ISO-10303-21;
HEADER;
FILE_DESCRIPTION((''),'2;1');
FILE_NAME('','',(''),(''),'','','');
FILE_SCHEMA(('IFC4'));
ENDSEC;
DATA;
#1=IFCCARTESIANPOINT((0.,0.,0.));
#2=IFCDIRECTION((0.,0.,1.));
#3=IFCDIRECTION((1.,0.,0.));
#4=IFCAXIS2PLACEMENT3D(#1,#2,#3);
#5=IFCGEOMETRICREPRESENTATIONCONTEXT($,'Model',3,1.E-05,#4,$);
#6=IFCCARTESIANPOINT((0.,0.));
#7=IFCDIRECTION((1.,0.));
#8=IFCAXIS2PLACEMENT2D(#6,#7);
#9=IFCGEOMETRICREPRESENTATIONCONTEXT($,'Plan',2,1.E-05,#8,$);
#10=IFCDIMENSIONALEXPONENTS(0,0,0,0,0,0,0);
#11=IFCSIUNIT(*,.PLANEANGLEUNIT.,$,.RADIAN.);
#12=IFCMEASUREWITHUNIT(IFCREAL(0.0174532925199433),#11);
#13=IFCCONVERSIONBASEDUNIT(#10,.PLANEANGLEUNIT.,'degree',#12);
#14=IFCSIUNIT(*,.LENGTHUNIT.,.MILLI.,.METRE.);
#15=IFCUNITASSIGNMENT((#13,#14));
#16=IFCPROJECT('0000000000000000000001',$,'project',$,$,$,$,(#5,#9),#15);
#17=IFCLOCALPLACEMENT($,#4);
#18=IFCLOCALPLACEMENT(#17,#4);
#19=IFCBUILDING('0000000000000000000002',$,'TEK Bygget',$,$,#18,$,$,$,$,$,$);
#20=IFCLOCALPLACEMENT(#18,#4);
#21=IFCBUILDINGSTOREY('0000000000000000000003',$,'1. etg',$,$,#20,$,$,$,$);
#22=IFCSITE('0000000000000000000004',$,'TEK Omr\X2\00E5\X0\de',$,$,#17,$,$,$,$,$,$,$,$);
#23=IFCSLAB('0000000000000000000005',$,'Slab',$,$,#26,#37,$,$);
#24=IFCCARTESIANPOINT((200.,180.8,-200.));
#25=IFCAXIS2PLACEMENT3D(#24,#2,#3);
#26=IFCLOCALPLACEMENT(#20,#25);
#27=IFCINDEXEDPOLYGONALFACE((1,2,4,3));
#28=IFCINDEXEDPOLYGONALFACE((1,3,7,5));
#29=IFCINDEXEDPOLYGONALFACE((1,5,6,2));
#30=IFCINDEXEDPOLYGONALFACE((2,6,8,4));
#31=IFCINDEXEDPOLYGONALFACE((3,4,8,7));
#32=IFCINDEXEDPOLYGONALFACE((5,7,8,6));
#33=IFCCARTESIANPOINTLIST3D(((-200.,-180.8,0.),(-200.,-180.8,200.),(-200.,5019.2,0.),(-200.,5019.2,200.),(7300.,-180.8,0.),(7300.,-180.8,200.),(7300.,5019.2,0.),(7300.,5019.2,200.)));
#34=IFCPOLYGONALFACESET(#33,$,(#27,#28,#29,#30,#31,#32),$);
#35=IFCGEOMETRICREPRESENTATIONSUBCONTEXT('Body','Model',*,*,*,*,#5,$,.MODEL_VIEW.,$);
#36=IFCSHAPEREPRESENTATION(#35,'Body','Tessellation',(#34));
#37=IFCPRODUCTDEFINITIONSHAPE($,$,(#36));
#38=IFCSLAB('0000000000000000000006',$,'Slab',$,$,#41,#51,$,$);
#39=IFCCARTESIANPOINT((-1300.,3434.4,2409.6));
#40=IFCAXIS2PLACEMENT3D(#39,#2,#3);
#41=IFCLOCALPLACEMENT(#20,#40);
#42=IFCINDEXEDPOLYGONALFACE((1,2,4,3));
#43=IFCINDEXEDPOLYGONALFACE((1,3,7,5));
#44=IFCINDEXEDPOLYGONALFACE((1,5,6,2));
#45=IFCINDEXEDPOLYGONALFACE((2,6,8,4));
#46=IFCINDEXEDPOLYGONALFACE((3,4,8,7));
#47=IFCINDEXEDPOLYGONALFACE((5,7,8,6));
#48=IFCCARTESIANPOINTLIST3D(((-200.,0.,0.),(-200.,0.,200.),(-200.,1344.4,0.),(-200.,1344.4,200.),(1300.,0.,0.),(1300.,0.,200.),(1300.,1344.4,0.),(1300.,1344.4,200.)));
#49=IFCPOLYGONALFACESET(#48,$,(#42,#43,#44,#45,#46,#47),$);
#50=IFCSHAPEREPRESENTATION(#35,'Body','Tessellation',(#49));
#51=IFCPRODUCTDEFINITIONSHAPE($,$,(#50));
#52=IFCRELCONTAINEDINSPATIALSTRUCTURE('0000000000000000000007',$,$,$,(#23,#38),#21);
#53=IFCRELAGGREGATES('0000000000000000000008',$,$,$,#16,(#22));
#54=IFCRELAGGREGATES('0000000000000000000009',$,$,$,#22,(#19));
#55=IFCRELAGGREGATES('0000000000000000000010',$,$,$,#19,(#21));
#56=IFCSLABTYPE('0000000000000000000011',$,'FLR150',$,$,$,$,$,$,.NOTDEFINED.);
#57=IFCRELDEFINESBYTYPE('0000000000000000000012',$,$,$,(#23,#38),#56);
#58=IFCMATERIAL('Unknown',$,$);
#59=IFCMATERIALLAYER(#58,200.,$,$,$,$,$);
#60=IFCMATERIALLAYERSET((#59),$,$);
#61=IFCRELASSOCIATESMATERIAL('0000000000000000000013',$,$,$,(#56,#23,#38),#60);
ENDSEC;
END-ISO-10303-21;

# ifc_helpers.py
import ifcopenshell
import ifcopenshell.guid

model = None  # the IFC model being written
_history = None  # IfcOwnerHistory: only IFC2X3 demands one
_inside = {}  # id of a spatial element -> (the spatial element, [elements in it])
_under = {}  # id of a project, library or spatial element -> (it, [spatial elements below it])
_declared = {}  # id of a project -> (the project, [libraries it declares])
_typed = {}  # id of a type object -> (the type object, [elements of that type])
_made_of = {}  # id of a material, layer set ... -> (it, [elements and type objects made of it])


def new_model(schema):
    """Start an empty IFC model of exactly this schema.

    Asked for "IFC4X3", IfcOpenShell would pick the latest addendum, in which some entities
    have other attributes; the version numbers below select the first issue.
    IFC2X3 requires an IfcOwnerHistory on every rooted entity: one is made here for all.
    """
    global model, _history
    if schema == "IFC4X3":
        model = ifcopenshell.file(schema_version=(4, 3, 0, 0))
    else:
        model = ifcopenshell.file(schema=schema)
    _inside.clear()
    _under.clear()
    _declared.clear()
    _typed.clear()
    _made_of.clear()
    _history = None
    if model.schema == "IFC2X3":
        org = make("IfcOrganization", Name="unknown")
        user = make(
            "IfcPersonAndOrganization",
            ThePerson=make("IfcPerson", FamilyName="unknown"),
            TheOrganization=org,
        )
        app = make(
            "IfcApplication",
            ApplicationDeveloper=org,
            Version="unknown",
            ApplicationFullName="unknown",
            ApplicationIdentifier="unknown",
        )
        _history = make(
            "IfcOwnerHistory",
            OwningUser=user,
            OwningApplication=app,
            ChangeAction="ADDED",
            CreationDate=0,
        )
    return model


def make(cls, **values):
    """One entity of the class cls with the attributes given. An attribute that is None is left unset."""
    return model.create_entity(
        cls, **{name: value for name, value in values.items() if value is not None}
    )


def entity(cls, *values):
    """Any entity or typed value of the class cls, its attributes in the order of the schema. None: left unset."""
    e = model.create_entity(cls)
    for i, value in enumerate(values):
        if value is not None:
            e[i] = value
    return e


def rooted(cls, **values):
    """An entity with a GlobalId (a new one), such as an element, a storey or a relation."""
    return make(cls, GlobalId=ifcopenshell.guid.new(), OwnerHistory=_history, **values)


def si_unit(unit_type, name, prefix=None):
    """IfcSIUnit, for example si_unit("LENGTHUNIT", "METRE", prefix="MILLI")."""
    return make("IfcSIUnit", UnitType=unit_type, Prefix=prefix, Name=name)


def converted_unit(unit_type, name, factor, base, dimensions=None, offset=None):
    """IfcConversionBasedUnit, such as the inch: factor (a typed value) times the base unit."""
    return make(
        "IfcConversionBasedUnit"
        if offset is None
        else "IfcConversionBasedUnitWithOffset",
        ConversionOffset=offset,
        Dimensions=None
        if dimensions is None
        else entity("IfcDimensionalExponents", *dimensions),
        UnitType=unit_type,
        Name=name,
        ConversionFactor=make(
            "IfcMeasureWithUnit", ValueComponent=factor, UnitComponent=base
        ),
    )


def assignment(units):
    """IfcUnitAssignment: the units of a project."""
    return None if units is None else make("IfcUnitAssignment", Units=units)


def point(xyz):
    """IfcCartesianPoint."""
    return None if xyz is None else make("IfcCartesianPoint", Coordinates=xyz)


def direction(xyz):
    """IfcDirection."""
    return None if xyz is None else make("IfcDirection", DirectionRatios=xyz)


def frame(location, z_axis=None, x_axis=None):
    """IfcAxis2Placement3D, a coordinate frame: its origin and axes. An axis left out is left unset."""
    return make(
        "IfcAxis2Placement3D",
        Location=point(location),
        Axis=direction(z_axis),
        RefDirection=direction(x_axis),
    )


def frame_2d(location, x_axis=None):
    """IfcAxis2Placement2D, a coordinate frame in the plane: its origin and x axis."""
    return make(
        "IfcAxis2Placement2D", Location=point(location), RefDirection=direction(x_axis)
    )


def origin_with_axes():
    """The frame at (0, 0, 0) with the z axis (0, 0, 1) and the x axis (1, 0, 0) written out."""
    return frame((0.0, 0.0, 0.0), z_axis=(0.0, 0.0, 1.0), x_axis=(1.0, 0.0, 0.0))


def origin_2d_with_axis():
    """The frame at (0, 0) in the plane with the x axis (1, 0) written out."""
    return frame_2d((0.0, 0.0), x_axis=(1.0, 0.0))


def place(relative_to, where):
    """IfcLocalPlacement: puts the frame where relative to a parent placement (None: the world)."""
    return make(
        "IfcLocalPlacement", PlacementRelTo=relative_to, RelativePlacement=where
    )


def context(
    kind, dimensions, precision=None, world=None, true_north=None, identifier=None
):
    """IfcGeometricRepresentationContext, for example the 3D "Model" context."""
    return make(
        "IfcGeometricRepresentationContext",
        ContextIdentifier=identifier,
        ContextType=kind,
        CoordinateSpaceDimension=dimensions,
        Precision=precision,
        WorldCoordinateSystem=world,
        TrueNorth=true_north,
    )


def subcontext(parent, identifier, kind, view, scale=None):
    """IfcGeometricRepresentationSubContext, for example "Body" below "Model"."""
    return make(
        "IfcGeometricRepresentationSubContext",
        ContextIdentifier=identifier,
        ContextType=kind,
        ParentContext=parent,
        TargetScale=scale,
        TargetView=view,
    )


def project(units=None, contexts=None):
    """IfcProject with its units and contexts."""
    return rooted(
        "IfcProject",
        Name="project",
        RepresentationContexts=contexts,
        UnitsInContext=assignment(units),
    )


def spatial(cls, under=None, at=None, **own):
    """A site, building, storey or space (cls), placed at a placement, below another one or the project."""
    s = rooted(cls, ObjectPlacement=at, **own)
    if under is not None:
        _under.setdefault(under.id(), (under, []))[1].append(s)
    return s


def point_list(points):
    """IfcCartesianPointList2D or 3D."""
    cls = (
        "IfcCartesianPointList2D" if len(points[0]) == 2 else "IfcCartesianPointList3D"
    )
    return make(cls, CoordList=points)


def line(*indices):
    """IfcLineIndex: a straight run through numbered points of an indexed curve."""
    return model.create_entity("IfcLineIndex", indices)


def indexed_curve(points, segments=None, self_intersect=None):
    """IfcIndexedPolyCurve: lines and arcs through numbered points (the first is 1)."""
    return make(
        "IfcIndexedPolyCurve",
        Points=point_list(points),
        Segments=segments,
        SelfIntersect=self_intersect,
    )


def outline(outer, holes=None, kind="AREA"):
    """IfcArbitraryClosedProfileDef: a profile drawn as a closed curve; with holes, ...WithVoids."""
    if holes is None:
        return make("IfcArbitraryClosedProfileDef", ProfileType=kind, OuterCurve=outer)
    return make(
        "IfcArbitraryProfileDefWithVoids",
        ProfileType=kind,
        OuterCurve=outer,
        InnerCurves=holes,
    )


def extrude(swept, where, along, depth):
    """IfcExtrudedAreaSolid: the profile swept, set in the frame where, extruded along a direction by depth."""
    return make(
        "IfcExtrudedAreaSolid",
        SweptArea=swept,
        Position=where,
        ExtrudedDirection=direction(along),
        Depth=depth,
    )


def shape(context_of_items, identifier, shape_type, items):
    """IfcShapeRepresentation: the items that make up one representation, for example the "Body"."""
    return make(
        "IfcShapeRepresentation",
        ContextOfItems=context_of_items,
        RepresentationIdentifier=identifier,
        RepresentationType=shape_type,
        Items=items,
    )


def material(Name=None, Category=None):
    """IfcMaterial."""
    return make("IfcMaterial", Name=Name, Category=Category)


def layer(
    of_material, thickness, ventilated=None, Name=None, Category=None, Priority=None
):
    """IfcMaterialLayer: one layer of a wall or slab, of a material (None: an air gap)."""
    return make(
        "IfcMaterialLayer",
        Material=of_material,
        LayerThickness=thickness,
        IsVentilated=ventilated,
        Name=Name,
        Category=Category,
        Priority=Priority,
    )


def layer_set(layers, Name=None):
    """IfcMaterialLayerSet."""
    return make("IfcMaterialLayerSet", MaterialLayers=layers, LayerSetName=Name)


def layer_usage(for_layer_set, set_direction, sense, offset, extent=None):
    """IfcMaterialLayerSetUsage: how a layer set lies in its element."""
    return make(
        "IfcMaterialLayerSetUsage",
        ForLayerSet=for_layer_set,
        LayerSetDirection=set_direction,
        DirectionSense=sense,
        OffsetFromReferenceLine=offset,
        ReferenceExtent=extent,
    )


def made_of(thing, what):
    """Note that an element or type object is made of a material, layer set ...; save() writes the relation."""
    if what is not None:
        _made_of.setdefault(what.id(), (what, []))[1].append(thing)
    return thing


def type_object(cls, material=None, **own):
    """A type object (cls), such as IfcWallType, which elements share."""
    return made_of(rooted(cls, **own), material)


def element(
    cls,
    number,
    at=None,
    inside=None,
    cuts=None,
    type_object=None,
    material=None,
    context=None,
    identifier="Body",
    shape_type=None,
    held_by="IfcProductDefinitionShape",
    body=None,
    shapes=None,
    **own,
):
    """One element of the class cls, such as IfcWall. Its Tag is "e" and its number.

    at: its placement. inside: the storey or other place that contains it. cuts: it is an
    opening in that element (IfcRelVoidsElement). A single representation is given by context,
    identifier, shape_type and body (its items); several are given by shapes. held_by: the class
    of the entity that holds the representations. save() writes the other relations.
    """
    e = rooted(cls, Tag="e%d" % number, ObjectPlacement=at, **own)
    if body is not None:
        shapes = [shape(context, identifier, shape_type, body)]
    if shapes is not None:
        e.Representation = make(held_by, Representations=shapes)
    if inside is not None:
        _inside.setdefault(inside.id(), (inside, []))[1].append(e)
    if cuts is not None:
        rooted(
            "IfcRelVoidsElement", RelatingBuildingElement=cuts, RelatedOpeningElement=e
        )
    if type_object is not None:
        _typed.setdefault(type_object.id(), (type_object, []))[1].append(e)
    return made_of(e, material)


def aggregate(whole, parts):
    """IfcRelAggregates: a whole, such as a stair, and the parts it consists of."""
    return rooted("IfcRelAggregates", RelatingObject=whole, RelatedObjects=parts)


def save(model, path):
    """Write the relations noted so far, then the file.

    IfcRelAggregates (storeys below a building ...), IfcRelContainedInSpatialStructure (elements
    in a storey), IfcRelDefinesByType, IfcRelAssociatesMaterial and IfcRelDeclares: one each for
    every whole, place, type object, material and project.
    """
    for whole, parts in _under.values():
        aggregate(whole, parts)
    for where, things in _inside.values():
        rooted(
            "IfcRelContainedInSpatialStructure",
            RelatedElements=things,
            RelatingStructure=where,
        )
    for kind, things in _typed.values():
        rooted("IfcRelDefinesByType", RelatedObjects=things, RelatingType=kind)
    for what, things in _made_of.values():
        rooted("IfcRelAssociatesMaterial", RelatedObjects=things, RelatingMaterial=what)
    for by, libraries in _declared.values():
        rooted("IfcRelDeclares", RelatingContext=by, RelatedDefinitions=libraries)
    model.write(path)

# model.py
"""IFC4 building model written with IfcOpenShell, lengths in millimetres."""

from ifc_helpers import new_model, entity, si_unit, converted_unit, frame, origin_with_axes, origin_2d_with_axis, place, context, subcontext, project, spatial, line, indexed_curve, outline, extrude, material, layer, layer_set, layer_usage, type_object, element, save


model = new_model("IFC4")

# Units and contexts
model_context = context("Model", 3, precision=1e-05, world=origin_with_axes())
plan_context = context("Plan", 2, precision=1e-05, world=origin_2d_with_axis())
body_context = subcontext(model_context, "Body", "Model", "MODEL_VIEW")
ifc_project = project(units=[converted_unit("PLANEANGLEUNIT", "degree", entity("IfcReal", 0.0174532925199433), si_unit("PLANEANGLEUNIT", "RADIAN"), dimensions=[0, 0, 0, 0, 0, 0, 0]), si_unit("LENGTHUNIT", "METRE", prefix="MILLI")], contexts=[model_context, plan_context])

# Site, building, storey
site_placement = place(None, origin_with_axes())
site = spatial("IfcSite", under=ifc_project, at=site_placement, Name="TEK Område")
building_placement = place(site_placement, origin_with_axes())
building = spatial("IfcBuilding", under=site, at=building_placement, Name="TEK Bygget")
storey_placement = place(building_placement, origin_with_axes())
storey = spatial("IfcBuildingStorey", under=building, at=storey_placement, Name="1. etg")

# Shared definitions
ifc_material = material(Name="Unknown")

# Slabs
ifc_layer_1 = layer(ifc_material, 200.0)
ifc_layer_set_1 = layer_set([ifc_layer_1])
ifc_layer_usage_1 = layer_usage(ifc_layer_set_1, "AXIS3", "POSITIVE", 0.0)
slab_type = type_object("IfcSlabType", Name="FLR150", PredefinedType="NOTDEFINED", material=ifc_layer_set_1)
slab_1_placement = place(storey_placement, frame((200.0, 180.8, -200.0), z_axis=(0.0, 0.0, 1.0), x_axis=(1.0, 0.0, 0.0)))
element("IfcSlab", 1, at=slab_1_placement, inside=storey, type_object=slab_type, material=ifc_layer_usage_1, Name="Slab", context=body_context, shape_type="SweptSolid", body=[
    extrude(outline(indexed_curve([(7300.0, 5019.2), (7300.0, -180.8), (-200.0, -180.8), (-200.0, 5019.2)], segments=[line(3, 2), line(2, 1), line(1, 4), line(4, 3)], self_intersect=False)), None, (0.0, 0.0, 1.0), 200.0),
])
ifc_layer_usage_2 = layer_usage(ifc_layer_set_1, "AXIS3", "POSITIVE", 0.0)
slab_2_placement = place(storey_placement, frame((-1300.0, 3434.4, 2409.6), z_axis=(0.0, 0.0, 1.0), x_axis=(1.0, 0.0, 0.0)))
element("IfcSlab", 2, at=slab_2_placement, inside=storey, type_object=slab_type, material=ifc_layer_usage_2, Name="Slab", context=body_context, shape_type="SweptSolid", body=[
    extrude(outline(indexed_curve([(-200.0, 1344.4), (1300.0, 1344.4), (1300.0, 0.0), (-200.0, 0.0)], segments=[line(4, 1), line(1, 2), line(2, 3), line(3, 4)], self_intersect=False)), None, (0.0, 0.0, 1.0), 200.0),
])

save(model, "model.ifc")
